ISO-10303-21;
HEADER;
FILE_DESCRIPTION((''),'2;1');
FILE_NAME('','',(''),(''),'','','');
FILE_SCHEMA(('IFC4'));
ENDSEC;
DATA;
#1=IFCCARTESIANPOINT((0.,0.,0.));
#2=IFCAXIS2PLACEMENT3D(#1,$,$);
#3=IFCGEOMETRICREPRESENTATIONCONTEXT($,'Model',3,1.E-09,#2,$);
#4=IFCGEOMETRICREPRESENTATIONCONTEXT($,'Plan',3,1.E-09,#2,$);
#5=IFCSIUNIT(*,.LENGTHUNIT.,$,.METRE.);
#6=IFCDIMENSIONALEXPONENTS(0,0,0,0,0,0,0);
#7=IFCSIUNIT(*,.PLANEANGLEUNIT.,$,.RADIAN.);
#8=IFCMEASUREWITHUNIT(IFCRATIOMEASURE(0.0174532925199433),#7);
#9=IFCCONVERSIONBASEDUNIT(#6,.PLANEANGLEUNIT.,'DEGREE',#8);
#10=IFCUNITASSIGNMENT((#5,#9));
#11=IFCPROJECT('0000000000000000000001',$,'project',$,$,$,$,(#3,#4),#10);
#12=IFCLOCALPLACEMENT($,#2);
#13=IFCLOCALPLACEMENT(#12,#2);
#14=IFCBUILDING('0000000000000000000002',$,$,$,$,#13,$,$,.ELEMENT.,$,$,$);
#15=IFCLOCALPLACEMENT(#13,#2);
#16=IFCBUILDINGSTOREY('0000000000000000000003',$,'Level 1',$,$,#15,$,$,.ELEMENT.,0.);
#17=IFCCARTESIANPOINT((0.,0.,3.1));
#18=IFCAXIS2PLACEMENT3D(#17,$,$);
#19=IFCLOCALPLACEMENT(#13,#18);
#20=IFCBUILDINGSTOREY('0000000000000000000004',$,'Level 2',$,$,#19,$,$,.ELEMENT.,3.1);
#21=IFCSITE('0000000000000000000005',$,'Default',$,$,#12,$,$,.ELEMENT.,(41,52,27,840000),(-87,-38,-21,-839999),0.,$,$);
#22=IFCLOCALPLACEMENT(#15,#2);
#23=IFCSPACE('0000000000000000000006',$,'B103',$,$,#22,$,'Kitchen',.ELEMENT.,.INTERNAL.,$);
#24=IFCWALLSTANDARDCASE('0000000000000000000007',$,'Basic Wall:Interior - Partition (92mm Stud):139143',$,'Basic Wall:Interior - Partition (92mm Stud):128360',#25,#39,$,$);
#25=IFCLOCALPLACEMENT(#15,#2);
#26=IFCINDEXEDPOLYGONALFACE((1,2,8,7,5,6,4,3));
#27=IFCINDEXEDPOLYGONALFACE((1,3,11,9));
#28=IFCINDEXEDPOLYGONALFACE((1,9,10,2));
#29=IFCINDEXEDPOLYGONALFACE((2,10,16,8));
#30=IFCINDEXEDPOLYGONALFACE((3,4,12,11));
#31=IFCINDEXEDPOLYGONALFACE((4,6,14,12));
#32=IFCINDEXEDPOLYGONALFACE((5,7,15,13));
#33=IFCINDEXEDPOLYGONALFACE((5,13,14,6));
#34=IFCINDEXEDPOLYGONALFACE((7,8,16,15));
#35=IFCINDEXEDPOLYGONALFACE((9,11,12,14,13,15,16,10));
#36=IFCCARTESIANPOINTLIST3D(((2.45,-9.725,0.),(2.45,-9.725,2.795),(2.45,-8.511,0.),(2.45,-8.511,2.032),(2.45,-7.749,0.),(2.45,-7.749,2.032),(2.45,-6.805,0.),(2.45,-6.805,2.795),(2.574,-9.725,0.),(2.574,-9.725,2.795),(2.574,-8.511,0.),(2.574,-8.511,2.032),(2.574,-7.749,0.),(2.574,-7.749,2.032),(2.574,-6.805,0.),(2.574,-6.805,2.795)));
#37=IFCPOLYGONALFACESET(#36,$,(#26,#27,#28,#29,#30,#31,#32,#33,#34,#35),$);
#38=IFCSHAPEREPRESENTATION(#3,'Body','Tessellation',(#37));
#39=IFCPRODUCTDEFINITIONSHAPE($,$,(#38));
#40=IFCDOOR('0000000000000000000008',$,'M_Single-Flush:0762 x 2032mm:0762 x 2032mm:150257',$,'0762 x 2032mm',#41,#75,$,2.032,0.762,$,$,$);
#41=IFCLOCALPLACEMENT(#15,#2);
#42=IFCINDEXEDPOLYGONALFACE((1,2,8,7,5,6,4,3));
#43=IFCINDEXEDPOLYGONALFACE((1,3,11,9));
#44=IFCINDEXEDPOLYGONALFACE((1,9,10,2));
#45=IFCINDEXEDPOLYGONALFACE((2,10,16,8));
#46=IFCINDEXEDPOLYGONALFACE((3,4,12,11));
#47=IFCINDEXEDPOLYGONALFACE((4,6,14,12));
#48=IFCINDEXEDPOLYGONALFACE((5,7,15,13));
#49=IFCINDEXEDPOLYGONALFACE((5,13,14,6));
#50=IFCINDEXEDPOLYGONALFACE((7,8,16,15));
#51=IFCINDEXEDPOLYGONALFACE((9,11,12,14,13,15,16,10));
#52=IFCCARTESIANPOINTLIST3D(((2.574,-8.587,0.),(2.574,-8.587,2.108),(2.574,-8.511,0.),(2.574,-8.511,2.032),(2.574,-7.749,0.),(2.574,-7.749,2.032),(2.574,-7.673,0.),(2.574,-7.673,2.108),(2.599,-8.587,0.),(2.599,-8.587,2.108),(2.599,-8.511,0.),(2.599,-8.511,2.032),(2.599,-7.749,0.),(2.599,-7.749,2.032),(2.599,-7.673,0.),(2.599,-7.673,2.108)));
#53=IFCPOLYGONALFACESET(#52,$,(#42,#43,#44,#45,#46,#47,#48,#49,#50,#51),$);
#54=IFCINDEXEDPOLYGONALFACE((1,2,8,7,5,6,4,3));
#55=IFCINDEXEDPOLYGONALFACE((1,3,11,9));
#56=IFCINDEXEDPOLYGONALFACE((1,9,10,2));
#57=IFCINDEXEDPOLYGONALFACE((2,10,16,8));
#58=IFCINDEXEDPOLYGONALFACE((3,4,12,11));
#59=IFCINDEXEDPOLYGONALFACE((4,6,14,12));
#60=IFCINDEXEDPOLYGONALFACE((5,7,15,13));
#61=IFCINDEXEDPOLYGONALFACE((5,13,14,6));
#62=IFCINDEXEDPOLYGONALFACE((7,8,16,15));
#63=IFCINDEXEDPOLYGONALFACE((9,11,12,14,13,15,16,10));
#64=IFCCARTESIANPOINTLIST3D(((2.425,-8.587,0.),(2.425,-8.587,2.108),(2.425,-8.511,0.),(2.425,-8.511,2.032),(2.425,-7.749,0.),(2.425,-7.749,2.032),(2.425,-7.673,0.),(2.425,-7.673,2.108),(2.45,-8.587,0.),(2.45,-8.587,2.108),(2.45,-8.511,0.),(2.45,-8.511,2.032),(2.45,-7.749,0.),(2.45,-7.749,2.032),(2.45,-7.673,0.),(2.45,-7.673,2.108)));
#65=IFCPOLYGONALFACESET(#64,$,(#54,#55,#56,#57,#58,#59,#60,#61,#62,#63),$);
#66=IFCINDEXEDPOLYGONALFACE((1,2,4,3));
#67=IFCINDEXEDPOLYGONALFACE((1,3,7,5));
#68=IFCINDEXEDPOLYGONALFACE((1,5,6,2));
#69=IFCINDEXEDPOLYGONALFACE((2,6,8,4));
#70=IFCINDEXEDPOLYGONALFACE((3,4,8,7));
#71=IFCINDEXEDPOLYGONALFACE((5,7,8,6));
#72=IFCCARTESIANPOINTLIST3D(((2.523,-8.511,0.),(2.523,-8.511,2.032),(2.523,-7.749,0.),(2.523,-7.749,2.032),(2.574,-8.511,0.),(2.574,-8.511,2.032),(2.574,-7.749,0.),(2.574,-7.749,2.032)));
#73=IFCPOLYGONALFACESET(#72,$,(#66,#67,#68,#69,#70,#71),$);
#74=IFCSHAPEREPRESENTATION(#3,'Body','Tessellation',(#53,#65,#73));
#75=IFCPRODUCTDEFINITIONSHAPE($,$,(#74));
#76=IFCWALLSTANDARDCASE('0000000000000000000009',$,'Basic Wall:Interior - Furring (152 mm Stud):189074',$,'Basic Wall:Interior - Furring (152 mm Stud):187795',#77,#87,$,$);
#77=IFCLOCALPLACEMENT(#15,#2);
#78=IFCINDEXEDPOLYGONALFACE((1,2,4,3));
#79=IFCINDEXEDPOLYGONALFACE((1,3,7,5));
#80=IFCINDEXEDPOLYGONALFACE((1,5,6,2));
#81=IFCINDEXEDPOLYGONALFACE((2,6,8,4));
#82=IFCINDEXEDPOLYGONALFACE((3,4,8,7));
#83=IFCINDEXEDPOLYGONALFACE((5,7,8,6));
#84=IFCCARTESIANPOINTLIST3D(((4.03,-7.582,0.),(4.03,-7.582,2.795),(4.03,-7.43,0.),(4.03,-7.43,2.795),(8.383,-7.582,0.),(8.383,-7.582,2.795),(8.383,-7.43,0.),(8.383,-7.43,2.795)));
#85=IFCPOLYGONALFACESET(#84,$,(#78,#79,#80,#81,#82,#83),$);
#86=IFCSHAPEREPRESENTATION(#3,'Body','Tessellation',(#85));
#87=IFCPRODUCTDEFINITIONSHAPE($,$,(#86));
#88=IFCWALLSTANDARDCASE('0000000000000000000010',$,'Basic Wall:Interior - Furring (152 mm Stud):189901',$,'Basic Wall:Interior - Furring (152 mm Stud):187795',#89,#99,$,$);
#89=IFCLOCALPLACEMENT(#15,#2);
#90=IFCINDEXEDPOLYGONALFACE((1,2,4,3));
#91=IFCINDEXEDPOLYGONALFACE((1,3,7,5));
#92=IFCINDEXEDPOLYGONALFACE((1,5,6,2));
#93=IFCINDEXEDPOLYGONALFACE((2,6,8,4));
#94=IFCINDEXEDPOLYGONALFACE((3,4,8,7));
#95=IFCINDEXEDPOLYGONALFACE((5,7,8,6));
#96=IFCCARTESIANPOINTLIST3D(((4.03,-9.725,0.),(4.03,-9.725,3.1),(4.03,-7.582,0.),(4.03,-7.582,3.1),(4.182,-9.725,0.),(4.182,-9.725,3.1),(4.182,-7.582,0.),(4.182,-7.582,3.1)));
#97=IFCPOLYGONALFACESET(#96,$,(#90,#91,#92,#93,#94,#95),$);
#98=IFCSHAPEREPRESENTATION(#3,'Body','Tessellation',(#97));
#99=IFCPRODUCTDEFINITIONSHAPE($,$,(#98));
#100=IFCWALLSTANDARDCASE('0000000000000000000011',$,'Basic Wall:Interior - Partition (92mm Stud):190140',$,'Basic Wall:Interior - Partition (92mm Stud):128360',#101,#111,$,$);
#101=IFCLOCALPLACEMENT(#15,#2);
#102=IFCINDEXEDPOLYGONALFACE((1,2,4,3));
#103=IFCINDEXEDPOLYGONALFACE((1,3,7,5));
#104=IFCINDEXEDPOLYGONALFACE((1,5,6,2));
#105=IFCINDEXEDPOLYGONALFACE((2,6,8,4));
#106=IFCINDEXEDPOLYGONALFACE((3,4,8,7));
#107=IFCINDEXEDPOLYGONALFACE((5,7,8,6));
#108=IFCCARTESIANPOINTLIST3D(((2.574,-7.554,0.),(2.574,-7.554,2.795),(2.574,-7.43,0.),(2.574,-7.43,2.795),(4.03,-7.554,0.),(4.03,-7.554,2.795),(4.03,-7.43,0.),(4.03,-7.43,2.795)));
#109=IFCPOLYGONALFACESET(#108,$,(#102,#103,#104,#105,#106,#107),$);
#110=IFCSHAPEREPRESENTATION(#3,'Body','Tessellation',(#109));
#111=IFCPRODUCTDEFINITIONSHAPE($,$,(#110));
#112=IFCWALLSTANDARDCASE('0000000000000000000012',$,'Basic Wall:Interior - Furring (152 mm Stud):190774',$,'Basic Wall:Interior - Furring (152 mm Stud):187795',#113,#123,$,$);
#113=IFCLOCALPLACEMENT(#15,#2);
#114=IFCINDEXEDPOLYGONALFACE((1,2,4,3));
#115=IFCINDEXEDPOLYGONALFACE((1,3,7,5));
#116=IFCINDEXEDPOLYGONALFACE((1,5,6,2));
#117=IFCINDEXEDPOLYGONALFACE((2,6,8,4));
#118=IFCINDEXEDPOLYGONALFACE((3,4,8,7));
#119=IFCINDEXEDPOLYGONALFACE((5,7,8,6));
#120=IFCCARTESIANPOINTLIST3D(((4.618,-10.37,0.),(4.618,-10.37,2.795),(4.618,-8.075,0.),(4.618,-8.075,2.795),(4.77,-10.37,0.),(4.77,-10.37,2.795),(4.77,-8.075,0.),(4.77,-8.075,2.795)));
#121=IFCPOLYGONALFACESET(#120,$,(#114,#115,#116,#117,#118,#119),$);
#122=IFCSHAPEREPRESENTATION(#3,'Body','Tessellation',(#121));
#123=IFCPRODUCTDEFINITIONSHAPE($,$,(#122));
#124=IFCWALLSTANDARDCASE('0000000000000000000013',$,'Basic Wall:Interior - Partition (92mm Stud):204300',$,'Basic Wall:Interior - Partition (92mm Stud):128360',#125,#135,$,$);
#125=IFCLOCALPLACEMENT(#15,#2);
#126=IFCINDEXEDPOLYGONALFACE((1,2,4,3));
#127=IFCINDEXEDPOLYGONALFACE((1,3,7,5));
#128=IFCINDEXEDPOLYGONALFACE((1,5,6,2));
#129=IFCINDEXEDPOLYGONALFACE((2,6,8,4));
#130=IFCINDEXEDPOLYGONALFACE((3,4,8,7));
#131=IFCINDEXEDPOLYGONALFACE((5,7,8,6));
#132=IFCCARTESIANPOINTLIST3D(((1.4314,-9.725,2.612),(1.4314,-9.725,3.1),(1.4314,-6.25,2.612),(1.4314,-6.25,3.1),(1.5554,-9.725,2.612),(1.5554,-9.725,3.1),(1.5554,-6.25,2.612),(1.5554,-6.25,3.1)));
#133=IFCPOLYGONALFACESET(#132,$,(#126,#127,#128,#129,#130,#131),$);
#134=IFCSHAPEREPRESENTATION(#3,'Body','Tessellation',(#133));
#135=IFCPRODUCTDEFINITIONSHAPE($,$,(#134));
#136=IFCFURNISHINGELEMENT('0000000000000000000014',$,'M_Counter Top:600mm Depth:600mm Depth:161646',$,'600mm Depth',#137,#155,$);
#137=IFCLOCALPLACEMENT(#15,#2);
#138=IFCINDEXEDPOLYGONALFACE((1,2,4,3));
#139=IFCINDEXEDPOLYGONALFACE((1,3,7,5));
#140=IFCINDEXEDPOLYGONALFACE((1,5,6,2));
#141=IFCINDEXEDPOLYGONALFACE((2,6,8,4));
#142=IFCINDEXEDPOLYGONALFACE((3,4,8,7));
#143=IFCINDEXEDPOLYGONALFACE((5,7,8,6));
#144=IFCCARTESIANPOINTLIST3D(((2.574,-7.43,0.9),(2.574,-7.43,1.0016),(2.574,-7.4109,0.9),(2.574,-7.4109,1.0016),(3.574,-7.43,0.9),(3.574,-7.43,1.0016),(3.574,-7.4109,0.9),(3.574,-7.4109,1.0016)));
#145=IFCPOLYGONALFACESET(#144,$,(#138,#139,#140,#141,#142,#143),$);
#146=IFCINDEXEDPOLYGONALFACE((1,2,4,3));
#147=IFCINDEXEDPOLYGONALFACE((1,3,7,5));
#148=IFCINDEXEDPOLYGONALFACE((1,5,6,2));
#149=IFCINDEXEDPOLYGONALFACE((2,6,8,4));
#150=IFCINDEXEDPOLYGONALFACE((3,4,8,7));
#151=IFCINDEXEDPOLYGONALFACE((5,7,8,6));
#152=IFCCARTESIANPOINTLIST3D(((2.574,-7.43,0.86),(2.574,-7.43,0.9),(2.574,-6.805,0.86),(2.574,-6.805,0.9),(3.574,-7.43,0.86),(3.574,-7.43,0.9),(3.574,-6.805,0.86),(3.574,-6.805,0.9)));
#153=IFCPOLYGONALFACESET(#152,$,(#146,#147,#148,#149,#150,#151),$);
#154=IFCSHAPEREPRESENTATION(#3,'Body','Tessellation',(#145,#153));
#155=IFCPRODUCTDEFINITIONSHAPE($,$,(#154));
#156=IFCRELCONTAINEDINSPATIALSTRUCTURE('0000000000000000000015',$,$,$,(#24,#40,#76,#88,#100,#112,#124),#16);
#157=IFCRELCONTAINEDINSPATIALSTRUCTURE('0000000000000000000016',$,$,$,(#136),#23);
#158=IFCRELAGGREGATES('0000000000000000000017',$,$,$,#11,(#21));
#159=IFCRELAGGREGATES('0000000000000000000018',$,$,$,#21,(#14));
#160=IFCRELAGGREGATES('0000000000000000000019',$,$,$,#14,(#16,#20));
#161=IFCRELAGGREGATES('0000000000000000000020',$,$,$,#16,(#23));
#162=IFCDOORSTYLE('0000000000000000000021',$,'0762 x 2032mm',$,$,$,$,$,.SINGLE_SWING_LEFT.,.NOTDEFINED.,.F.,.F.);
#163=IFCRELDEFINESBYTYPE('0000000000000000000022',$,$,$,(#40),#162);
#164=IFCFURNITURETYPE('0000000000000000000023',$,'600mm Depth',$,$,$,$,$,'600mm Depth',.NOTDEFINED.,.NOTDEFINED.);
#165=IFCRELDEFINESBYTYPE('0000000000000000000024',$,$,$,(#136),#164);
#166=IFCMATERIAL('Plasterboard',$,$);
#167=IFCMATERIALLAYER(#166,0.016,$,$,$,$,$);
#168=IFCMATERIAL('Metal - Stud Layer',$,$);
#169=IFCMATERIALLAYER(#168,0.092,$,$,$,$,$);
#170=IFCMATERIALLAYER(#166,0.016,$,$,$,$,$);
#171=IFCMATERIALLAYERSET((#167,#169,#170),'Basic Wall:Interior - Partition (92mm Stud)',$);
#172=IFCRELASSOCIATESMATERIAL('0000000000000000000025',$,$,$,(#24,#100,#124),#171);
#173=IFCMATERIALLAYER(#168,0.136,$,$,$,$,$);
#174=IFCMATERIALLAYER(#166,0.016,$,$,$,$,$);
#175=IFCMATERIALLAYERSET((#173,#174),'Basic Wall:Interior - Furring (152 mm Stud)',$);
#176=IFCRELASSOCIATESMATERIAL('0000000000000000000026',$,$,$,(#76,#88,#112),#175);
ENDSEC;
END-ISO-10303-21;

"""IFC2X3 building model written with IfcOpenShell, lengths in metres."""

from ifc_helpers import new_model, entity, si_unit, converted_unit, frame, frame_2d, origin, origin_2d_with_axis, place, context, project, spatial, polyline, rectangle, outline, extrude, clip, bounded_halfspace, source, transform, mapped, material, layer, layer_set, layer_usage, type_object, type_shapes, element, fill, save


model = new_model("IFC2X3")

# Units and contexts
model_context = context("Model", 3, precision=1e-09, world=origin())
plan_context = context("Plan", 3, precision=1e-09, world=origin())
ifc_project = project(units=[si_unit("LENGTHUNIT", "METRE"), converted_unit("PLANEANGLEUNIT", "DEGREE", entity("IfcRatioMeasure", 0.0174532925199433), si_unit("PLANEANGLEUNIT", "RADIAN"), dimensions=[0, 0, 0, 0, 0, 0, 0])], contexts=[model_context, plan_context])

# Site, building, storey
site_placement = place(None, origin())
site = spatial("IfcSite", under=ifc_project, at=site_placement, Name="Default", CompositionType="ELEMENT", RefLatitude=(41, 52, 27, 840000), RefLongitude=(-87, -38, -21, -839999), RefElevation=0.0)
building_placement = place(site_placement, origin())
building = spatial("IfcBuilding", under=site, at=building_placement, CompositionType="ELEMENT")
storey_1_placement = place(building_placement, origin())
storey_1 = spatial("IfcBuildingStorey", under=building, at=storey_1_placement, Name="Level 1", CompositionType="ELEMENT", Elevation=0.0)

# Shared definitions
ifc_material_1 = material(Name="Metal - Stud Layer")
ifc_material_2 = material(Name="Plasterboard")

# Shared definitions
ifc_layer_1 = layer(ifc_material_2, 0.016)
ifc_layer_2 = layer(ifc_material_1, 0.092)
ifc_layer_3 = layer(ifc_material_2, 0.016)
ifc_layer_set_1 = layer_set([ifc_layer_1, ifc_layer_2, ifc_layer_3], Name="Basic Wall:Interior - Partition (92mm Stud)")

# Wall, opening, door
ifc_layer_usage_1 = layer_usage(ifc_layer_set_1, "AXIS2", "NEGATIVE", 0.062)
wall_1_placement = place(storey_1_placement, frame((2.512, -6.805, 0.0), z_axis=(0.0, 0.0, 1.0), x_axis=(0.0, -1.0, 0.0)))
wall_1 = element("IfcWallStandardCase", 1, at=wall_1_placement, inside=storey_1, material=ifc_layer_usage_1, Name="Basic Wall:Interior - Partition (92mm Stud):139143", ObjectType="Basic Wall:Interior - Partition (92mm Stud):128360", context=model_context, shape_type="SweptSolid", body=[
    extrude(rectangle(XDim=2.92, YDim=0.124, at=frame_2d((1.46, 0.0), x_axis=(-1.0, 0.0))), origin(), (0.0, 0.0, 1.0), 2.795),
])
opening_1_placement = place(wall_1_placement, frame((0.944, -0.062, 0.0)))
opening_1 = element("IfcOpeningElement", 2, at=opening_1_placement, cuts=wall_1, ObjectType="Opening", context=model_context, shape_type="SweptSolid", body=[
    extrude(rectangle(XDim=0.762, YDim=2.032, at=frame_2d((1.016, 0.381), x_axis=(0.0, -1.0))), frame((0.0, 0.0, 0.0), z_axis=(0.0, 1.0, 0.0), x_axis=(0.0, 0.0, 1.0)), (0.0, 0.0, 1.0), 0.124),
])
door_style_1 = type_object("IfcDoorStyle", Name="0762 x 2032mm", ConstructionType="NOTDEFINED", OperationType="SINGLE_SWING_LEFT", ParameterTakesPrecedence=False, Sizeable=False)
shared_shape_1 = source(origin(), model_context, "Body", "SweptSolid", [
    extrude(outline(polyline([(-0.457, -1.073), (0.457, -1.073), (0.457, 1.035), (0.381, 1.035), (0.381, -0.997), (-0.381, -0.997), (-0.381, 1.035), (-0.457, 1.035), (-0.457, -1.073)])), frame((0.381, 0.149, 1.035), z_axis=(0.0, -1.0, 0.0), x_axis=(-1.0, 0.0, 0.0)), (0.0, 0.0, 1.0), 0.025),
    extrude(outline(polyline([(-1.073, -0.457), (1.035, -0.457), (1.035, -0.381), (-0.997, -0.381), (-0.997, 0.381), (1.035, 0.381), (1.035, 0.457), (-1.073, 0.457), (-1.073, -0.457)])), frame((0.381, 0.0, 1.035), z_axis=(0.0, -1.0, 0.0), x_axis=(0.0, 0.0, -1.0)), (0.0, 0.0, 1.0), 0.025),
    extrude(rectangle(XDim=0.762, YDim=0.051, at=origin_2d_with_axis()), frame((0.381, 0.0985, 0.0)), (0.0, 0.0, 1.0), 2.032),
])
type_shapes(door_style_1, [shared_shape_1])
door_1_placement = place(opening_1_placement, origin())
door_1 = element("IfcDoor", 3, at=door_1_placement, inside=storey_1, type_object=door_style_1, Name="M_Single-Flush:0762 x 2032mm:0762 x 2032mm:150257", ObjectType="0762 x 2032mm", OverallHeight=2.032, OverallWidth=0.762, context=model_context, shape_type="MappedRepresentation", body=[
    mapped(shared_shape_1, transform((0.0, 0.0, 0.0), scale=1.0)),
])
fill(opening_1, door_1)

# Shared definitions
storey_2_placement = place(building_placement, frame((0.0, 0.0, 3.1)))
storey_2 = spatial("IfcBuildingStorey", under=building, at=storey_2_placement, Name="Level 2", CompositionType="ELEMENT", Elevation=3.1)

# Walls
ifc_layer_4 = layer(ifc_material_1, 0.136)
ifc_layer_5 = layer(ifc_material_2, 0.016)
ifc_layer_set_2 = layer_set([ifc_layer_4, ifc_layer_5], Name="Basic Wall:Interior - Furring (152 mm Stud)")
ifc_layer_usage_2 = layer_usage(ifc_layer_set_2, "AXIS2", "NEGATIVE", 0.076)
wall_2_placement = place(storey_1_placement, frame((8.383, -7.506, 0.0), z_axis=(0.0, 0.0, 1.0), x_axis=(-1.0, 0.0, 0.0)))
element("IfcWallStandardCase", 4, at=wall_2_placement, inside=storey_1, material=ifc_layer_usage_2, Name="Basic Wall:Interior - Furring (152 mm Stud):189074", ObjectType="Basic Wall:Interior - Furring (152 mm Stud):187795", context=model_context, shape_type="Clipping", body=[
    clip(extrude(rectangle(XDim=4.353, YDim=0.152, at=frame_2d((2.1765, 0.0), x_axis=(-1.0, 0.0))), origin(), (0.0, 0.0, 1.0), 2.795), bounded_halfspace(frame((0.0, -0.076, 2.795), z_axis=(0.0, 0.0, -1.0), x_axis=(0.0, 1.0, 0.0)), True, frame((0.0, -0.076, 2.795)), polyline([(0.0, 0.0), (3.708, 0.0), (3.708, 0.152), (0.0, 0.152), (0.0, 0.0)]))),
])
ifc_layer_usage_3 = layer_usage(ifc_layer_set_2, "AXIS2", "POSITIVE", -0.076)
wall_3_placement = place(storey_1_placement, frame((4.106, -9.725, 0.0), z_axis=(0.0, 0.0, 1.0), x_axis=(0.0, 1.0, 0.0)))
element("IfcWallStandardCase", 5, at=wall_3_placement, inside=storey_1, material=ifc_layer_usage_3, Name="Basic Wall:Interior - Furring (152 mm Stud):189901", ObjectType="Basic Wall:Interior - Furring (152 mm Stud):187795", context=model_context, shape_type="SweptSolid", body=[
    extrude(rectangle(XDim=2.143, YDim=0.152, at=frame_2d((1.0715, 0.0), x_axis=(-1.0, 0.0))), origin(), (0.0, 0.0, 1.0), 3.1),
])
ifc_layer_usage_4 = layer_usage(ifc_layer_set_1, "AXIS2", "NEGATIVE", 0.062)
wall_4_placement = place(storey_1_placement, frame((4.03, -7.492, 0.0), z_axis=(0.0, 0.0, 1.0), x_axis=(-1.0, 0.0, 0.0)))
element("IfcWallStandardCase", 6, at=wall_4_placement, inside=storey_1, material=ifc_layer_usage_4, Name="Basic Wall:Interior - Partition (92mm Stud):190140", ObjectType="Basic Wall:Interior - Partition (92mm Stud):128360", context=model_context, shape_type="SweptSolid", body=[
    extrude(rectangle(XDim=1.456, YDim=0.124, at=frame_2d((0.728, 0.0), x_axis=(-1.0, 0.0))), origin(), (0.0, 0.0, 1.0), 2.795),
])
ifc_layer_usage_5 = layer_usage(ifc_layer_set_2, "AXIS2", "POSITIVE", -0.076)
wall_5_placement = place(storey_1_placement, frame((4.694, -8.075, 0.0), z_axis=(0.0, 0.0, 1.0), x_axis=(0.0, -1.0, 0.0)))
element("IfcWallStandardCase", 7, at=wall_5_placement, inside=storey_1, material=ifc_layer_usage_5, Name="Basic Wall:Interior - Furring (152 mm Stud):190774", ObjectType="Basic Wall:Interior - Furring (152 mm Stud):187795", context=model_context, shape_type="SweptSolid", body=[
    extrude(rectangle(XDim=2.295, YDim=0.152, at=frame_2d((1.1475, 0.0), x_axis=(-1.0, 0.0))), origin(), (0.0, 0.0, 1.0), 2.795),
])
ifc_layer_usage_6 = layer_usage(ifc_layer_set_1, "AXIS2", "NEGATIVE", 0.062)
wall_6_placement = place(storey_1_placement, frame((1.4934, -6.25, 2.612), z_axis=(0.0, 0.0, 1.0), x_axis=(0.0, -1.0, 0.0)))
element("IfcWallStandardCase", 8, at=wall_6_placement, inside=storey_1, material=ifc_layer_usage_6, Name="Basic Wall:Interior - Partition (92mm Stud):204300", ObjectType="Basic Wall:Interior - Partition (92mm Stud):128360", context=model_context, shape_type="SweptSolid", body=[
    extrude(rectangle(XDim=3.475, YDim=0.124, at=frame_2d((1.7375, 0.0), x_axis=(-1.0, 0.0))), origin(), (0.0, 0.0, 1.0), 0.488),
])

# Shared definitions
space_1_placement = place(storey_1_placement, origin())
space_1 = spatial("IfcSpace", under=storey_1, at=space_1_placement, Name="B103", LongName="Kitchen", CompositionType="ELEMENT", InteriorOrExteriorSpace="INTERNAL")

# Furnishing element
furniture_type_1 = type_object("IfcFurnitureType", Name="600mm Depth", ElementType="600mm Depth", AssemblyPlace="NOTDEFINED")
shared_shape_2 = source(origin(), model_context, "Body", "SweptSolid", [
    extrude(rectangle(XDim=0.0191, YDim=1.0, at=origin_2d_with_axis()), frame((-0.7005, -0.0095, 0.9), z_axis=(0.0, 0.0, 1.0), x_axis=(0.0, -1.0, 0.0)), (0.0, 0.0, 1.0), 0.1016),
    extrude(rectangle(XDim=1.0, YDim=0.625, at=origin_2d_with_axis()), frame((-0.7005, -0.3125, 0.86), z_axis=(0.0, 0.0, 1.0), x_axis=(-1.0, 0.0, 0.0)), (0.0, 0.0, 1.0), 0.04),
])
type_shapes(furniture_type_1, [shared_shape_2])
furnishing_1_placement = place(space_1_placement, frame((2.3735, -7.43, 0.0), z_axis=(0.0, 0.0, 1.0), x_axis=(-1.0, 0.0, 0.0)))
element("IfcFurnishingElement", 9, at=furnishing_1_placement, inside=space_1, type_object=furniture_type_1, Name="M_Counter Top:600mm Depth:600mm Depth:161646", ObjectType="600mm Depth", context=model_context, shape_type="MappedRepresentation", body=[
    mapped(shared_shape_2, transform((0.0, 0.0, 0.0), scale=1.0)),
])

save(model, "model.ifc")
